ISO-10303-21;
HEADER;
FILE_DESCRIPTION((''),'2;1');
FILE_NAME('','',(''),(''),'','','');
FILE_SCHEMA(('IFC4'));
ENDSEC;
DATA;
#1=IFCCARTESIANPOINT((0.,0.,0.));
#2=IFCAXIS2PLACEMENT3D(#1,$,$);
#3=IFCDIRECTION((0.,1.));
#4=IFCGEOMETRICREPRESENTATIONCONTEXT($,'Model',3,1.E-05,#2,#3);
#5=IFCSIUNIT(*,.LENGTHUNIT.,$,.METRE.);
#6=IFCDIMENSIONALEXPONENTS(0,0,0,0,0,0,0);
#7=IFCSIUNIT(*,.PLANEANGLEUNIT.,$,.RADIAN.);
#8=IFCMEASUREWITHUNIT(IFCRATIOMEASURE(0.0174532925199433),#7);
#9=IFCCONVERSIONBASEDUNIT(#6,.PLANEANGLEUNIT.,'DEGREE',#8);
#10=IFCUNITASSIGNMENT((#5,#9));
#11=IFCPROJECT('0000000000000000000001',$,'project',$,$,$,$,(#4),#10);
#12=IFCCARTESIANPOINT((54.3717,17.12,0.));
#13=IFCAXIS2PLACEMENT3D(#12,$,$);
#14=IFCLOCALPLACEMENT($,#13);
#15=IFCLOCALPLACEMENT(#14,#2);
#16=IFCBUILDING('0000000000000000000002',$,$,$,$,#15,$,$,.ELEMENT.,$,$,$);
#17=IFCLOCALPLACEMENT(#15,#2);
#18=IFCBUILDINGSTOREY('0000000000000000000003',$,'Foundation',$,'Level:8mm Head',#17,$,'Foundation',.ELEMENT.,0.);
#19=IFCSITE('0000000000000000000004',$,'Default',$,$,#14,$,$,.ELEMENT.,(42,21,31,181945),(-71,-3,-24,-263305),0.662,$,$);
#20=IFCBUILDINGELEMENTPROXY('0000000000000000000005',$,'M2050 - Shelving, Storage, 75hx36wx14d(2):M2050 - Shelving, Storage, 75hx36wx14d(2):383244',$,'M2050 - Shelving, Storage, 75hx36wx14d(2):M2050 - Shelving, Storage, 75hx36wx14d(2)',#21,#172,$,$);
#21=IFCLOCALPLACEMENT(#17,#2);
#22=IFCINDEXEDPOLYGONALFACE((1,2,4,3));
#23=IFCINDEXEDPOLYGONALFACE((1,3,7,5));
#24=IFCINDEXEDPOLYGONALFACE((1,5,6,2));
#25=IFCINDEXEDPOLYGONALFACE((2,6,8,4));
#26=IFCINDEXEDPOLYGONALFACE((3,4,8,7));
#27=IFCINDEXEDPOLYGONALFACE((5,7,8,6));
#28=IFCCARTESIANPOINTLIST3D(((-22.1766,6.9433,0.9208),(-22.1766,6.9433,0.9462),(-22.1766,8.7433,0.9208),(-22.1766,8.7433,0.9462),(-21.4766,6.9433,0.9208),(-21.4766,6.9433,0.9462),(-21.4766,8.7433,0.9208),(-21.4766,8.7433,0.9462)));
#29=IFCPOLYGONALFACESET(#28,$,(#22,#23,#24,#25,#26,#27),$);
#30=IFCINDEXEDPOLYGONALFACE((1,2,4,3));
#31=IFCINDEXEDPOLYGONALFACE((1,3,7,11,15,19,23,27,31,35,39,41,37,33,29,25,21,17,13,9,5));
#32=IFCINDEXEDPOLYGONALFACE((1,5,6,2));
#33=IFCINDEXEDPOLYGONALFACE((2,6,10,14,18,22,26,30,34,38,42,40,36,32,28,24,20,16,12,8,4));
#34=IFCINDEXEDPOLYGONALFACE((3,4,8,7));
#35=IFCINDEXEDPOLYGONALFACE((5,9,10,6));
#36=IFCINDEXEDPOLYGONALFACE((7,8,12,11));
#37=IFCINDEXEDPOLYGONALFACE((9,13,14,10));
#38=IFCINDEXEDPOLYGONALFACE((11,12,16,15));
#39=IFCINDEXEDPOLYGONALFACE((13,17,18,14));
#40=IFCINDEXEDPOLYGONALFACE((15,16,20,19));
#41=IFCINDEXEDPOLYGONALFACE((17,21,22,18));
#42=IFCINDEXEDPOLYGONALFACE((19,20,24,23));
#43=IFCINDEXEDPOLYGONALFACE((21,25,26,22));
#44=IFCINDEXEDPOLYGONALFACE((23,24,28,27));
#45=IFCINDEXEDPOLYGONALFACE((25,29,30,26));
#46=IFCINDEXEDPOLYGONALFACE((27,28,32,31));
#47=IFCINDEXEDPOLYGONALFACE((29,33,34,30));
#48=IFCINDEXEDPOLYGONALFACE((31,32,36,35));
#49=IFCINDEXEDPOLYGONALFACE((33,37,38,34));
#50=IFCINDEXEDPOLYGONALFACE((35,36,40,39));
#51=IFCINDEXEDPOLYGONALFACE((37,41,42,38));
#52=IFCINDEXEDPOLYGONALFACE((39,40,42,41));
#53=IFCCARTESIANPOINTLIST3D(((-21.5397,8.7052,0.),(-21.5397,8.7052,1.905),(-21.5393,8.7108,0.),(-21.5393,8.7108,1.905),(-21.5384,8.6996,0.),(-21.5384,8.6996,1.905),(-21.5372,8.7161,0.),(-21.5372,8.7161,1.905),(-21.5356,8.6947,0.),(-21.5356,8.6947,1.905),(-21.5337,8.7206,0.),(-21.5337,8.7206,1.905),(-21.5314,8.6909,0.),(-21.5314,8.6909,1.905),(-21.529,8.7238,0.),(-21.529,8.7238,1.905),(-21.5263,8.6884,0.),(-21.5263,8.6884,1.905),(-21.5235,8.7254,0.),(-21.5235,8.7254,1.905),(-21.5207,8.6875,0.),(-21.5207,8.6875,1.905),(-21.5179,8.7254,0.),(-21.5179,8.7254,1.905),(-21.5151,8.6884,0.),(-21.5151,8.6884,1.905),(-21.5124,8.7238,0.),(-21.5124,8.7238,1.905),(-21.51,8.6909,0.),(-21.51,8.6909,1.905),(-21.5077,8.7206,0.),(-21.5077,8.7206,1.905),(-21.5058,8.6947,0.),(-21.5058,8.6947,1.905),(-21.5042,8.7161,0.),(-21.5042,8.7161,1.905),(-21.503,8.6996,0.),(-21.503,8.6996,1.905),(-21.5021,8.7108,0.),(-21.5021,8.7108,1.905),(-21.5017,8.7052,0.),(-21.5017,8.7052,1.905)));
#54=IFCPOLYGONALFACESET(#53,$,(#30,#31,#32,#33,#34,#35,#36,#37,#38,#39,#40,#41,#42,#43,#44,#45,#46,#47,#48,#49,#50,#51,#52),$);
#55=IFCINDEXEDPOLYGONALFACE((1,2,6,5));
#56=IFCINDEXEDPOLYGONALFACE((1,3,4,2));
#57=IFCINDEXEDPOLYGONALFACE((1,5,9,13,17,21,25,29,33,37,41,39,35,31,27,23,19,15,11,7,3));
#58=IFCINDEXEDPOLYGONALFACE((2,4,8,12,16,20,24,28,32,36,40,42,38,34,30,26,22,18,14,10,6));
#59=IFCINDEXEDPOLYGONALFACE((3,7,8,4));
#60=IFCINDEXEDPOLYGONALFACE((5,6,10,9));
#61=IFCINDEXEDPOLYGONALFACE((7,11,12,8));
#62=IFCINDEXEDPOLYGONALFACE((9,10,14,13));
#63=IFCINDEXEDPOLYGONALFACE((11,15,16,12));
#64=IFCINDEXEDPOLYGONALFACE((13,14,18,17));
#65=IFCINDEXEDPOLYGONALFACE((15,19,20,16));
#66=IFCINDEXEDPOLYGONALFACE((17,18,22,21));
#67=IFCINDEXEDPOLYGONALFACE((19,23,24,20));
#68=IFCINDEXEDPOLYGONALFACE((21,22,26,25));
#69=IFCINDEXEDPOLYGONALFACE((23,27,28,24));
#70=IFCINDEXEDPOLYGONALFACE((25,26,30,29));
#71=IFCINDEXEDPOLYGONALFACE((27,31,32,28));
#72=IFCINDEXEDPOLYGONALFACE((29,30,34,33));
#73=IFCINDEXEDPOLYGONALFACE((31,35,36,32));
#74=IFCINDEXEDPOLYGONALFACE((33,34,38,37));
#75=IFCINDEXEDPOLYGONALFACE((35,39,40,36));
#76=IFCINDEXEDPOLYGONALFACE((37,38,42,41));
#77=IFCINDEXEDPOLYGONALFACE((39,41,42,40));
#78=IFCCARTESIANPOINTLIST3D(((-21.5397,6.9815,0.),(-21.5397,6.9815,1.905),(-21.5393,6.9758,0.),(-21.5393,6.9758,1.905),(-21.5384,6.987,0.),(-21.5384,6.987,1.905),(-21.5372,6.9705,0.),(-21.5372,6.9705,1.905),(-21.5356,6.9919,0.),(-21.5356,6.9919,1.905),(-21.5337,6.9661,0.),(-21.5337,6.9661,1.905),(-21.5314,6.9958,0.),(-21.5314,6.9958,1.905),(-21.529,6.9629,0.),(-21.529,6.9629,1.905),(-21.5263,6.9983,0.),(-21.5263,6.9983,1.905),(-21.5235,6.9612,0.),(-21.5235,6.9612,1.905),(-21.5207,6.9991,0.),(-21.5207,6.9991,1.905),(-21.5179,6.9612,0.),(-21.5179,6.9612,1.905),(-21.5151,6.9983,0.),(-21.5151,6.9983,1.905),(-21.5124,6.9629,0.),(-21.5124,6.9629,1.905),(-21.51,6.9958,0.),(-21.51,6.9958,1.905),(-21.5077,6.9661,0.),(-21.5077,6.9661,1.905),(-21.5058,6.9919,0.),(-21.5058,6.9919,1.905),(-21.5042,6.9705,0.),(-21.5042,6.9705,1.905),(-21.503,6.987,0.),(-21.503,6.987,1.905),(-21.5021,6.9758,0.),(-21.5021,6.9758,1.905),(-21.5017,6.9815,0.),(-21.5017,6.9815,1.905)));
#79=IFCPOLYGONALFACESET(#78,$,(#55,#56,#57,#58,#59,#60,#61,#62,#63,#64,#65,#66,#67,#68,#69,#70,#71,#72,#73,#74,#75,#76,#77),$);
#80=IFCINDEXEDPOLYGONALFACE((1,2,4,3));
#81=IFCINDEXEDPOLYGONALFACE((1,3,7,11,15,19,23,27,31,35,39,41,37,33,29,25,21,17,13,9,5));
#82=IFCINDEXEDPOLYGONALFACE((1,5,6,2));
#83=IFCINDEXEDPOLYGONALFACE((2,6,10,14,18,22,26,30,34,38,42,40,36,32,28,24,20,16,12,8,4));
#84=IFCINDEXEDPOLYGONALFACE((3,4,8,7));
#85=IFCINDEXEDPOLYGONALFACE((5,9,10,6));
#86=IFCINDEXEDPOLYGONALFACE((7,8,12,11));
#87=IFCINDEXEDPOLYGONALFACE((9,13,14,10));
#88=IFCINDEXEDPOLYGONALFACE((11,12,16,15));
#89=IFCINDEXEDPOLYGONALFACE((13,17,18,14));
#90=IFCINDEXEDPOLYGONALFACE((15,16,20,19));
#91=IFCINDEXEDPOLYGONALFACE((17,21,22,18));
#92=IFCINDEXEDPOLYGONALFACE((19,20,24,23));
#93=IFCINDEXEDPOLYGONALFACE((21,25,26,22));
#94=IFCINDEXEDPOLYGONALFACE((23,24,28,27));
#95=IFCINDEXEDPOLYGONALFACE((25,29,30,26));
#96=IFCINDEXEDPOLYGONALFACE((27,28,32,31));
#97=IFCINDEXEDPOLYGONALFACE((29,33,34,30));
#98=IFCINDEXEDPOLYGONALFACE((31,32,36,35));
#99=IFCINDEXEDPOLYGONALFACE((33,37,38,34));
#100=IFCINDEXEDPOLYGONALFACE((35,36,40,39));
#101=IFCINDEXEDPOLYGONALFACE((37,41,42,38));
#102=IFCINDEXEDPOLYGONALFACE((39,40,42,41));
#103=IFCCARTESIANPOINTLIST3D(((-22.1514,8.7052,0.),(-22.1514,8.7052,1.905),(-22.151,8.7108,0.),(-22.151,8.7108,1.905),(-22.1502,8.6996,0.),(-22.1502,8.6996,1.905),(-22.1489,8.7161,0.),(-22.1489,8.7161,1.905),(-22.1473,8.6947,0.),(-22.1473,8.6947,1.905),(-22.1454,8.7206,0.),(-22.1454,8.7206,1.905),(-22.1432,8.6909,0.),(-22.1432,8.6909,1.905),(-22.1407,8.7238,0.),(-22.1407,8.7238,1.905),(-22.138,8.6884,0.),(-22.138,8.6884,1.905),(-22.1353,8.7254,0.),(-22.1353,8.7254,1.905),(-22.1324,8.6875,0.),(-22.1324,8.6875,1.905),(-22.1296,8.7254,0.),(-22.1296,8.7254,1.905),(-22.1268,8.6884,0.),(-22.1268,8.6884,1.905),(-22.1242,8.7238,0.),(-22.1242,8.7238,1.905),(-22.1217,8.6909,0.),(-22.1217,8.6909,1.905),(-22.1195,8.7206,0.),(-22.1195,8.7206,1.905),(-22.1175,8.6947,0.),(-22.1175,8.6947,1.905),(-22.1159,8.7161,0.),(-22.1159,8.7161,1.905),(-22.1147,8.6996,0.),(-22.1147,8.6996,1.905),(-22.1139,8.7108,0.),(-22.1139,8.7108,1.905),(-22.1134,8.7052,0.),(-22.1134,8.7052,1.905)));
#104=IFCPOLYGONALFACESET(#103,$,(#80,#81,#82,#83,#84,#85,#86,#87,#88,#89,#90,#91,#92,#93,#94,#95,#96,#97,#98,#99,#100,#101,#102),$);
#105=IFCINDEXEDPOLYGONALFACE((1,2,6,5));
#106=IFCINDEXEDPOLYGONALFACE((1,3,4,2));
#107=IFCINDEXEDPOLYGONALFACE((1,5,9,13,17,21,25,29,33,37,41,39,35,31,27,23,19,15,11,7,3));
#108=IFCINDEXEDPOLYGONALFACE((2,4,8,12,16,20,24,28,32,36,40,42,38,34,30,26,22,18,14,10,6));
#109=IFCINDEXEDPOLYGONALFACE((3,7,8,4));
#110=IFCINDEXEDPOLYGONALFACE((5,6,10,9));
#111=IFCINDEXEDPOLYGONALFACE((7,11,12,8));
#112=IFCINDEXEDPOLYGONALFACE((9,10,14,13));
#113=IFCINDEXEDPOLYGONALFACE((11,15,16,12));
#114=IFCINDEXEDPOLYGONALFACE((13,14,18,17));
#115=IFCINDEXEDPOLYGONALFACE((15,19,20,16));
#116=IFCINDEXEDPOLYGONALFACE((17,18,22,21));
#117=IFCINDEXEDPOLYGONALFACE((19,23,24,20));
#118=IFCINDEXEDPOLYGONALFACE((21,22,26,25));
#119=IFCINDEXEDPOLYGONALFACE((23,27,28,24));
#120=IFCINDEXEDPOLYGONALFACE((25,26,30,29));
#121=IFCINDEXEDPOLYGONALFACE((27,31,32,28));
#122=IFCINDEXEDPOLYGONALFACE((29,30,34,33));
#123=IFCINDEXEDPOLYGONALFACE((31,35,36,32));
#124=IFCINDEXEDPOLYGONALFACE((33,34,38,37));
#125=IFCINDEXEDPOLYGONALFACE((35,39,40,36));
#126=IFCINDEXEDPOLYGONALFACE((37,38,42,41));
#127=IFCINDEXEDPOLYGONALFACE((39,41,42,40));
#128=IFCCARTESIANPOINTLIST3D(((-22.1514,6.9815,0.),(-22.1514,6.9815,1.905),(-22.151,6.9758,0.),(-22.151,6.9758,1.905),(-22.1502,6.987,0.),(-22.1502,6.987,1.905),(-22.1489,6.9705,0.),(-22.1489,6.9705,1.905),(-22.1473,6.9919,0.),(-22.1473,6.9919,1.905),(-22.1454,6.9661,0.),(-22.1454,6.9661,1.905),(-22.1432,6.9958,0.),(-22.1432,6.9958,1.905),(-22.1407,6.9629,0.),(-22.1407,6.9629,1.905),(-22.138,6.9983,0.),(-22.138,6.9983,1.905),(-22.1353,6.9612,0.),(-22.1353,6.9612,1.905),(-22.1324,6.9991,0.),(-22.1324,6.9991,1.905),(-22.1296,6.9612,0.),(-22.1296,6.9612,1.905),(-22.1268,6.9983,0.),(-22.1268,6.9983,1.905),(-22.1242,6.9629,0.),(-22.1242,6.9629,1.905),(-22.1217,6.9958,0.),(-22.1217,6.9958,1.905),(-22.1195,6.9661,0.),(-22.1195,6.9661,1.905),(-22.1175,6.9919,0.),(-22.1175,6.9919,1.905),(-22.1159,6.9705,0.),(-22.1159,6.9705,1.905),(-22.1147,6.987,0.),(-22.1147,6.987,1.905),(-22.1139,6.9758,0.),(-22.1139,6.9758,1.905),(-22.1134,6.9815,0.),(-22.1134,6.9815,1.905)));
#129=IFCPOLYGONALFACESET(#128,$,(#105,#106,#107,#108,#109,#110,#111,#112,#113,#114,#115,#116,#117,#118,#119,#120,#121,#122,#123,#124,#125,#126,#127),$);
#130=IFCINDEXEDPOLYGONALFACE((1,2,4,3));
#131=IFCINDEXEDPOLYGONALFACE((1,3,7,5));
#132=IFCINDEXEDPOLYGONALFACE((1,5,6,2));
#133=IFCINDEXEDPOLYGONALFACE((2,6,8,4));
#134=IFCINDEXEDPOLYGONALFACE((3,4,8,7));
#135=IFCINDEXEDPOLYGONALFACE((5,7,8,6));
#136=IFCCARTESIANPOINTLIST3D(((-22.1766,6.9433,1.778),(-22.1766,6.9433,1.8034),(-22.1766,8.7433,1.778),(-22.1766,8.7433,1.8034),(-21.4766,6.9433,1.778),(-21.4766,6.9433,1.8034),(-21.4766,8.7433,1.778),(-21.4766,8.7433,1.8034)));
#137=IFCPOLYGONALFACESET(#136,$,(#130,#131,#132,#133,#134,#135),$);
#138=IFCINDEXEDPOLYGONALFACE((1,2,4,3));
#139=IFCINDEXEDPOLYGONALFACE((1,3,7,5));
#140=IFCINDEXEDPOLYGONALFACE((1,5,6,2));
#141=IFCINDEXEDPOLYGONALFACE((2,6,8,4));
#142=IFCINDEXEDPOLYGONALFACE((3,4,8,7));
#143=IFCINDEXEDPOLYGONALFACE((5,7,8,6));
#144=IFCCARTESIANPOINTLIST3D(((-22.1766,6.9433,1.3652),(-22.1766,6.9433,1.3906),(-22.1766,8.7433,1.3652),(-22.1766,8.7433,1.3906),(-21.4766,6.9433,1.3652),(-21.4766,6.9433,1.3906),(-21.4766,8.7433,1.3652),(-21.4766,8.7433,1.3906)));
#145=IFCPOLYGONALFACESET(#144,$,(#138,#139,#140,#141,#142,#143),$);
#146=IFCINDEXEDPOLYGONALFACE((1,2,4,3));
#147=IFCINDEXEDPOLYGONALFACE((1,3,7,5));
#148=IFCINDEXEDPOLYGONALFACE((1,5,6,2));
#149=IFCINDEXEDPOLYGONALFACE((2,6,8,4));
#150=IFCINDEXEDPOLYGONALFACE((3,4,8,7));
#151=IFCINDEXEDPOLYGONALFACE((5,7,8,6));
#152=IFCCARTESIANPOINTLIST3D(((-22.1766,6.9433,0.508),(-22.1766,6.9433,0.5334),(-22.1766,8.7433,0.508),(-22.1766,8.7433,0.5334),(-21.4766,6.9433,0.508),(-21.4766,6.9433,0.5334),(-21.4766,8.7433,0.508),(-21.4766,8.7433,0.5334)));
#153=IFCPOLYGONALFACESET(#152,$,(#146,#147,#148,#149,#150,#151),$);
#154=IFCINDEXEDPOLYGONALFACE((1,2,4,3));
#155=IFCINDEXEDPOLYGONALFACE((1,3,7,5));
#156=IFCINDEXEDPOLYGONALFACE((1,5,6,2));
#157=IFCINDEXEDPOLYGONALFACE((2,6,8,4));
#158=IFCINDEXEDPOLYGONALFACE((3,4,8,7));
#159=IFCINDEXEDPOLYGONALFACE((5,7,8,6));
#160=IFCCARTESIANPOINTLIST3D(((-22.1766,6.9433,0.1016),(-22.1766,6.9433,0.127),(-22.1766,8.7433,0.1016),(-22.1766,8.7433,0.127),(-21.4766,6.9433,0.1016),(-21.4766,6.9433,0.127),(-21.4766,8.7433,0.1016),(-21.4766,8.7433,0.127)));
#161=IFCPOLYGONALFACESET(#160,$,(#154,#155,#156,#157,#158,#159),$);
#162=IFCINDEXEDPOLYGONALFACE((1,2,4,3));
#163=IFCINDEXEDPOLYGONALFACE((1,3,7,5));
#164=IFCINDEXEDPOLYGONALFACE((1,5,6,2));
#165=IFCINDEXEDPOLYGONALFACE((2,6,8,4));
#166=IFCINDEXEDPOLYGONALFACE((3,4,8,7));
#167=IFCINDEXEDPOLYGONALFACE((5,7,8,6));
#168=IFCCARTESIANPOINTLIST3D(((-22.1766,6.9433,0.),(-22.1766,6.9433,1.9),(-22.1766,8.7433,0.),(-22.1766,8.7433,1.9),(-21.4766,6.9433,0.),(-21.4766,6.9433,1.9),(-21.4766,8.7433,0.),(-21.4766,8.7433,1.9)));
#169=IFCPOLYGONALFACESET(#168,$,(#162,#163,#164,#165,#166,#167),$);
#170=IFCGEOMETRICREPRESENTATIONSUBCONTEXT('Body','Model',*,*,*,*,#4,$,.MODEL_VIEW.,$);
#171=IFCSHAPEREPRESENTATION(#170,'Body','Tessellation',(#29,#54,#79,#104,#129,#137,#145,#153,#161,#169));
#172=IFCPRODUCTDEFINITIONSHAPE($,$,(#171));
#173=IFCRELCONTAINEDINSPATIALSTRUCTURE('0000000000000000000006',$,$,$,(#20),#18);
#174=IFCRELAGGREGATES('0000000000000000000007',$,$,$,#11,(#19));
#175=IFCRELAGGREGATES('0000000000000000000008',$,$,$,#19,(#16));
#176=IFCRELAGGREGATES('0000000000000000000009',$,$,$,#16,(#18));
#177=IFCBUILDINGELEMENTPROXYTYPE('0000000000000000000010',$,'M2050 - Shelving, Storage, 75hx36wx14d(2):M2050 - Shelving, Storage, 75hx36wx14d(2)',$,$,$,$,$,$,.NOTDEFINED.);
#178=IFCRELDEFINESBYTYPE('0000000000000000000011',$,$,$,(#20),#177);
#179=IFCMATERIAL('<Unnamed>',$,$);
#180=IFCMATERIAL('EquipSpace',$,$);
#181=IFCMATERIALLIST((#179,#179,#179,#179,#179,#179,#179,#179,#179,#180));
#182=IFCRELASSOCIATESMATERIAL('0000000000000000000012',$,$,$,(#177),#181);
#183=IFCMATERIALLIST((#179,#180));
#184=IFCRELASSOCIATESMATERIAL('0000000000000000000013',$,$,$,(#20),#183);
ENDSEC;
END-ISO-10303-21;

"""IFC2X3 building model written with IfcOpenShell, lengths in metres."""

from ifc_helpers import new_model, entity, si_unit, converted_unit, direction, frame, frame_2d, origin, origin_2d_with_axis, place, context, subcontext, project, spatial, rectangle, circle, extrude, source, transform, mapped, material, material_list, type_object, type_shapes, element, save


model = new_model("IFC2X3")

# Units and contexts
model_context = context("Model", 3, precision=1e-05, world=origin(), true_north=direction((0.0, 1.0)))
body_context = subcontext(model_context, "Body", "Model", "MODEL_VIEW")
ifc_project = project(units=[si_unit("LENGTHUNIT", "METRE"), converted_unit("PLANEANGLEUNIT", "DEGREE", entity("IfcRatioMeasure", 0.0174532925199433), si_unit("PLANEANGLEUNIT", "RADIAN"), dimensions=[0, 0, 0, 0, 0, 0, 0])], contexts=[model_context])

# Site, building, storey
site_placement = place(None, frame((54.3717, 17.12, 0.0)))
site = spatial("IfcSite", under=ifc_project, at=site_placement, Name="Default", CompositionType="ELEMENT", RefLatitude=(42, 21, 31, 181945), RefLongitude=(-71, -3, -24, -263305), RefElevation=0.662)
building_placement = place(site_placement, origin())
building = spatial("IfcBuilding", under=site, at=building_placement, CompositionType="ELEMENT")
storey_placement = place(building_placement, origin())
storey = spatial("IfcBuildingStorey", under=building, at=storey_placement, Name="Foundation", ObjectType="Level:8mm Head", LongName="Foundation", CompositionType="ELEMENT", Elevation=0.0)

# Building element proxy
ifc_material_1 = material(Name="<Unnamed>")
ifc_material_2 = material(Name="EquipSpace")
ifc_material_list_1 = material_list([ifc_material_1, ifc_material_1, ifc_material_1, ifc_material_1, ifc_material_1, ifc_material_1, ifc_material_1, ifc_material_1, ifc_material_1, ifc_material_2])
building_element_proxy_type = type_object("IfcBuildingElementProxyType", Name="M2050 - Shelving, Storage, 75hx36wx14d(2):M2050 - Shelving, Storage, 75hx36wx14d(2)", PredefinedType="NOTDEFINED", material=ifc_material_list_1)
shared_shape = source(origin(), body_context, "Body", "SweptSolid", [
    extrude(rectangle(XDim=1.8, YDim=0.7, at=origin_2d_with_axis()), frame((0.0, 0.0, 0.9207), z_axis=(0.0, 0.0, 1.0), x_axis=(-1.0, 0.0, 0.0)), (0.0, 0.0, 1.0), 0.0254),
    extrude(circle(Radius=0.0191, at=origin_2d_with_axis()), frame((0.8633, -0.3059, 0.0), z_axis=(0.0, 0.0, 1.0), x_axis=(-1.0, 0.0, 0.0)), (0.0, 0.0, 1.0), 1.905),
    extrude(circle(Radius=0.0191, at=origin_2d_with_axis()), frame((-0.8633, -0.3059, 0.0)), (0.0, 0.0, 1.0), 1.905),
    extrude(circle(Radius=0.0191, at=origin_2d_with_axis()), frame((0.8633, 0.3059, 0.0), z_axis=(0.0, 0.0, 1.0), x_axis=(-1.0, 0.0, 0.0)), (0.0, 0.0, 1.0), 1.905),
    extrude(circle(Radius=0.0191, at=origin_2d_with_axis()), frame((-0.8633, 0.3059, 0.0)), (0.0, 0.0, 1.0), 1.905),
    extrude(rectangle(XDim=1.8, YDim=0.7, at=origin_2d_with_axis()), frame((0.0, 0.0, 1.778), z_axis=(0.0, 0.0, 1.0), x_axis=(-1.0, 0.0, 0.0)), (0.0, 0.0, 1.0), 0.0254),
    extrude(rectangle(XDim=1.8, YDim=0.7, at=origin_2d_with_axis()), frame((0.0, 0.0, 1.3653), z_axis=(0.0, 0.0, 1.0), x_axis=(-1.0, 0.0, 0.0)), (0.0, 0.0, 1.0), 0.0254),
    extrude(rectangle(XDim=1.8, YDim=0.7, at=origin_2d_with_axis()), frame((0.0, 0.0, 0.508), z_axis=(0.0, 0.0, 1.0), x_axis=(-1.0, 0.0, 0.0)), (0.0, 0.0, 1.0), 0.0254),
    extrude(rectangle(XDim=1.8, YDim=0.7, at=origin_2d_with_axis()), frame((0.0, 0.0, 0.1016), z_axis=(0.0, 0.0, 1.0), x_axis=(-1.0, 0.0, 0.0)), (0.0, 0.0, 1.0), 0.0254),
    extrude(rectangle(XDim=0.7, YDim=1.8, at=frame_2d((0.0, 0.18), x_axis=(1.0, 0.0))), frame((-0.18, 0.0, 0.0), z_axis=(0.0, 0.0, 1.0), x_axis=(0.0, -1.0, 0.0)), (0.0, 0.0, 1.0), 1.9),
])
type_shapes(building_element_proxy_type, [shared_shape])
ifc_material_list_2 = material_list([ifc_material_1, ifc_material_2])
proxy_1_placement = place(storey_placement, frame((-21.8266, 7.8433, 0.0), z_axis=(0.0, 0.0, 1.0), x_axis=(0.0, 1.0, 0.0)))
element("IfcBuildingElementProxy", 1, at=proxy_1_placement, inside=storey, type_object=building_element_proxy_type, material=ifc_material_list_2, Name="M2050 - Shelving, Storage, 75hx36wx14d(2):M2050 - Shelving, Storage, 75hx36wx14d(2):383244", ObjectType="M2050 - Shelving, Storage, 75hx36wx14d(2):M2050 - Shelving, Storage, 75hx36wx14d(2)", context=body_context, shape_type="MappedRepresentation", body=[
    mapped(shared_shape, transform((0.0, 0.0, 0.0), scale=1.0)),
])

save(model, "model.ifc")
